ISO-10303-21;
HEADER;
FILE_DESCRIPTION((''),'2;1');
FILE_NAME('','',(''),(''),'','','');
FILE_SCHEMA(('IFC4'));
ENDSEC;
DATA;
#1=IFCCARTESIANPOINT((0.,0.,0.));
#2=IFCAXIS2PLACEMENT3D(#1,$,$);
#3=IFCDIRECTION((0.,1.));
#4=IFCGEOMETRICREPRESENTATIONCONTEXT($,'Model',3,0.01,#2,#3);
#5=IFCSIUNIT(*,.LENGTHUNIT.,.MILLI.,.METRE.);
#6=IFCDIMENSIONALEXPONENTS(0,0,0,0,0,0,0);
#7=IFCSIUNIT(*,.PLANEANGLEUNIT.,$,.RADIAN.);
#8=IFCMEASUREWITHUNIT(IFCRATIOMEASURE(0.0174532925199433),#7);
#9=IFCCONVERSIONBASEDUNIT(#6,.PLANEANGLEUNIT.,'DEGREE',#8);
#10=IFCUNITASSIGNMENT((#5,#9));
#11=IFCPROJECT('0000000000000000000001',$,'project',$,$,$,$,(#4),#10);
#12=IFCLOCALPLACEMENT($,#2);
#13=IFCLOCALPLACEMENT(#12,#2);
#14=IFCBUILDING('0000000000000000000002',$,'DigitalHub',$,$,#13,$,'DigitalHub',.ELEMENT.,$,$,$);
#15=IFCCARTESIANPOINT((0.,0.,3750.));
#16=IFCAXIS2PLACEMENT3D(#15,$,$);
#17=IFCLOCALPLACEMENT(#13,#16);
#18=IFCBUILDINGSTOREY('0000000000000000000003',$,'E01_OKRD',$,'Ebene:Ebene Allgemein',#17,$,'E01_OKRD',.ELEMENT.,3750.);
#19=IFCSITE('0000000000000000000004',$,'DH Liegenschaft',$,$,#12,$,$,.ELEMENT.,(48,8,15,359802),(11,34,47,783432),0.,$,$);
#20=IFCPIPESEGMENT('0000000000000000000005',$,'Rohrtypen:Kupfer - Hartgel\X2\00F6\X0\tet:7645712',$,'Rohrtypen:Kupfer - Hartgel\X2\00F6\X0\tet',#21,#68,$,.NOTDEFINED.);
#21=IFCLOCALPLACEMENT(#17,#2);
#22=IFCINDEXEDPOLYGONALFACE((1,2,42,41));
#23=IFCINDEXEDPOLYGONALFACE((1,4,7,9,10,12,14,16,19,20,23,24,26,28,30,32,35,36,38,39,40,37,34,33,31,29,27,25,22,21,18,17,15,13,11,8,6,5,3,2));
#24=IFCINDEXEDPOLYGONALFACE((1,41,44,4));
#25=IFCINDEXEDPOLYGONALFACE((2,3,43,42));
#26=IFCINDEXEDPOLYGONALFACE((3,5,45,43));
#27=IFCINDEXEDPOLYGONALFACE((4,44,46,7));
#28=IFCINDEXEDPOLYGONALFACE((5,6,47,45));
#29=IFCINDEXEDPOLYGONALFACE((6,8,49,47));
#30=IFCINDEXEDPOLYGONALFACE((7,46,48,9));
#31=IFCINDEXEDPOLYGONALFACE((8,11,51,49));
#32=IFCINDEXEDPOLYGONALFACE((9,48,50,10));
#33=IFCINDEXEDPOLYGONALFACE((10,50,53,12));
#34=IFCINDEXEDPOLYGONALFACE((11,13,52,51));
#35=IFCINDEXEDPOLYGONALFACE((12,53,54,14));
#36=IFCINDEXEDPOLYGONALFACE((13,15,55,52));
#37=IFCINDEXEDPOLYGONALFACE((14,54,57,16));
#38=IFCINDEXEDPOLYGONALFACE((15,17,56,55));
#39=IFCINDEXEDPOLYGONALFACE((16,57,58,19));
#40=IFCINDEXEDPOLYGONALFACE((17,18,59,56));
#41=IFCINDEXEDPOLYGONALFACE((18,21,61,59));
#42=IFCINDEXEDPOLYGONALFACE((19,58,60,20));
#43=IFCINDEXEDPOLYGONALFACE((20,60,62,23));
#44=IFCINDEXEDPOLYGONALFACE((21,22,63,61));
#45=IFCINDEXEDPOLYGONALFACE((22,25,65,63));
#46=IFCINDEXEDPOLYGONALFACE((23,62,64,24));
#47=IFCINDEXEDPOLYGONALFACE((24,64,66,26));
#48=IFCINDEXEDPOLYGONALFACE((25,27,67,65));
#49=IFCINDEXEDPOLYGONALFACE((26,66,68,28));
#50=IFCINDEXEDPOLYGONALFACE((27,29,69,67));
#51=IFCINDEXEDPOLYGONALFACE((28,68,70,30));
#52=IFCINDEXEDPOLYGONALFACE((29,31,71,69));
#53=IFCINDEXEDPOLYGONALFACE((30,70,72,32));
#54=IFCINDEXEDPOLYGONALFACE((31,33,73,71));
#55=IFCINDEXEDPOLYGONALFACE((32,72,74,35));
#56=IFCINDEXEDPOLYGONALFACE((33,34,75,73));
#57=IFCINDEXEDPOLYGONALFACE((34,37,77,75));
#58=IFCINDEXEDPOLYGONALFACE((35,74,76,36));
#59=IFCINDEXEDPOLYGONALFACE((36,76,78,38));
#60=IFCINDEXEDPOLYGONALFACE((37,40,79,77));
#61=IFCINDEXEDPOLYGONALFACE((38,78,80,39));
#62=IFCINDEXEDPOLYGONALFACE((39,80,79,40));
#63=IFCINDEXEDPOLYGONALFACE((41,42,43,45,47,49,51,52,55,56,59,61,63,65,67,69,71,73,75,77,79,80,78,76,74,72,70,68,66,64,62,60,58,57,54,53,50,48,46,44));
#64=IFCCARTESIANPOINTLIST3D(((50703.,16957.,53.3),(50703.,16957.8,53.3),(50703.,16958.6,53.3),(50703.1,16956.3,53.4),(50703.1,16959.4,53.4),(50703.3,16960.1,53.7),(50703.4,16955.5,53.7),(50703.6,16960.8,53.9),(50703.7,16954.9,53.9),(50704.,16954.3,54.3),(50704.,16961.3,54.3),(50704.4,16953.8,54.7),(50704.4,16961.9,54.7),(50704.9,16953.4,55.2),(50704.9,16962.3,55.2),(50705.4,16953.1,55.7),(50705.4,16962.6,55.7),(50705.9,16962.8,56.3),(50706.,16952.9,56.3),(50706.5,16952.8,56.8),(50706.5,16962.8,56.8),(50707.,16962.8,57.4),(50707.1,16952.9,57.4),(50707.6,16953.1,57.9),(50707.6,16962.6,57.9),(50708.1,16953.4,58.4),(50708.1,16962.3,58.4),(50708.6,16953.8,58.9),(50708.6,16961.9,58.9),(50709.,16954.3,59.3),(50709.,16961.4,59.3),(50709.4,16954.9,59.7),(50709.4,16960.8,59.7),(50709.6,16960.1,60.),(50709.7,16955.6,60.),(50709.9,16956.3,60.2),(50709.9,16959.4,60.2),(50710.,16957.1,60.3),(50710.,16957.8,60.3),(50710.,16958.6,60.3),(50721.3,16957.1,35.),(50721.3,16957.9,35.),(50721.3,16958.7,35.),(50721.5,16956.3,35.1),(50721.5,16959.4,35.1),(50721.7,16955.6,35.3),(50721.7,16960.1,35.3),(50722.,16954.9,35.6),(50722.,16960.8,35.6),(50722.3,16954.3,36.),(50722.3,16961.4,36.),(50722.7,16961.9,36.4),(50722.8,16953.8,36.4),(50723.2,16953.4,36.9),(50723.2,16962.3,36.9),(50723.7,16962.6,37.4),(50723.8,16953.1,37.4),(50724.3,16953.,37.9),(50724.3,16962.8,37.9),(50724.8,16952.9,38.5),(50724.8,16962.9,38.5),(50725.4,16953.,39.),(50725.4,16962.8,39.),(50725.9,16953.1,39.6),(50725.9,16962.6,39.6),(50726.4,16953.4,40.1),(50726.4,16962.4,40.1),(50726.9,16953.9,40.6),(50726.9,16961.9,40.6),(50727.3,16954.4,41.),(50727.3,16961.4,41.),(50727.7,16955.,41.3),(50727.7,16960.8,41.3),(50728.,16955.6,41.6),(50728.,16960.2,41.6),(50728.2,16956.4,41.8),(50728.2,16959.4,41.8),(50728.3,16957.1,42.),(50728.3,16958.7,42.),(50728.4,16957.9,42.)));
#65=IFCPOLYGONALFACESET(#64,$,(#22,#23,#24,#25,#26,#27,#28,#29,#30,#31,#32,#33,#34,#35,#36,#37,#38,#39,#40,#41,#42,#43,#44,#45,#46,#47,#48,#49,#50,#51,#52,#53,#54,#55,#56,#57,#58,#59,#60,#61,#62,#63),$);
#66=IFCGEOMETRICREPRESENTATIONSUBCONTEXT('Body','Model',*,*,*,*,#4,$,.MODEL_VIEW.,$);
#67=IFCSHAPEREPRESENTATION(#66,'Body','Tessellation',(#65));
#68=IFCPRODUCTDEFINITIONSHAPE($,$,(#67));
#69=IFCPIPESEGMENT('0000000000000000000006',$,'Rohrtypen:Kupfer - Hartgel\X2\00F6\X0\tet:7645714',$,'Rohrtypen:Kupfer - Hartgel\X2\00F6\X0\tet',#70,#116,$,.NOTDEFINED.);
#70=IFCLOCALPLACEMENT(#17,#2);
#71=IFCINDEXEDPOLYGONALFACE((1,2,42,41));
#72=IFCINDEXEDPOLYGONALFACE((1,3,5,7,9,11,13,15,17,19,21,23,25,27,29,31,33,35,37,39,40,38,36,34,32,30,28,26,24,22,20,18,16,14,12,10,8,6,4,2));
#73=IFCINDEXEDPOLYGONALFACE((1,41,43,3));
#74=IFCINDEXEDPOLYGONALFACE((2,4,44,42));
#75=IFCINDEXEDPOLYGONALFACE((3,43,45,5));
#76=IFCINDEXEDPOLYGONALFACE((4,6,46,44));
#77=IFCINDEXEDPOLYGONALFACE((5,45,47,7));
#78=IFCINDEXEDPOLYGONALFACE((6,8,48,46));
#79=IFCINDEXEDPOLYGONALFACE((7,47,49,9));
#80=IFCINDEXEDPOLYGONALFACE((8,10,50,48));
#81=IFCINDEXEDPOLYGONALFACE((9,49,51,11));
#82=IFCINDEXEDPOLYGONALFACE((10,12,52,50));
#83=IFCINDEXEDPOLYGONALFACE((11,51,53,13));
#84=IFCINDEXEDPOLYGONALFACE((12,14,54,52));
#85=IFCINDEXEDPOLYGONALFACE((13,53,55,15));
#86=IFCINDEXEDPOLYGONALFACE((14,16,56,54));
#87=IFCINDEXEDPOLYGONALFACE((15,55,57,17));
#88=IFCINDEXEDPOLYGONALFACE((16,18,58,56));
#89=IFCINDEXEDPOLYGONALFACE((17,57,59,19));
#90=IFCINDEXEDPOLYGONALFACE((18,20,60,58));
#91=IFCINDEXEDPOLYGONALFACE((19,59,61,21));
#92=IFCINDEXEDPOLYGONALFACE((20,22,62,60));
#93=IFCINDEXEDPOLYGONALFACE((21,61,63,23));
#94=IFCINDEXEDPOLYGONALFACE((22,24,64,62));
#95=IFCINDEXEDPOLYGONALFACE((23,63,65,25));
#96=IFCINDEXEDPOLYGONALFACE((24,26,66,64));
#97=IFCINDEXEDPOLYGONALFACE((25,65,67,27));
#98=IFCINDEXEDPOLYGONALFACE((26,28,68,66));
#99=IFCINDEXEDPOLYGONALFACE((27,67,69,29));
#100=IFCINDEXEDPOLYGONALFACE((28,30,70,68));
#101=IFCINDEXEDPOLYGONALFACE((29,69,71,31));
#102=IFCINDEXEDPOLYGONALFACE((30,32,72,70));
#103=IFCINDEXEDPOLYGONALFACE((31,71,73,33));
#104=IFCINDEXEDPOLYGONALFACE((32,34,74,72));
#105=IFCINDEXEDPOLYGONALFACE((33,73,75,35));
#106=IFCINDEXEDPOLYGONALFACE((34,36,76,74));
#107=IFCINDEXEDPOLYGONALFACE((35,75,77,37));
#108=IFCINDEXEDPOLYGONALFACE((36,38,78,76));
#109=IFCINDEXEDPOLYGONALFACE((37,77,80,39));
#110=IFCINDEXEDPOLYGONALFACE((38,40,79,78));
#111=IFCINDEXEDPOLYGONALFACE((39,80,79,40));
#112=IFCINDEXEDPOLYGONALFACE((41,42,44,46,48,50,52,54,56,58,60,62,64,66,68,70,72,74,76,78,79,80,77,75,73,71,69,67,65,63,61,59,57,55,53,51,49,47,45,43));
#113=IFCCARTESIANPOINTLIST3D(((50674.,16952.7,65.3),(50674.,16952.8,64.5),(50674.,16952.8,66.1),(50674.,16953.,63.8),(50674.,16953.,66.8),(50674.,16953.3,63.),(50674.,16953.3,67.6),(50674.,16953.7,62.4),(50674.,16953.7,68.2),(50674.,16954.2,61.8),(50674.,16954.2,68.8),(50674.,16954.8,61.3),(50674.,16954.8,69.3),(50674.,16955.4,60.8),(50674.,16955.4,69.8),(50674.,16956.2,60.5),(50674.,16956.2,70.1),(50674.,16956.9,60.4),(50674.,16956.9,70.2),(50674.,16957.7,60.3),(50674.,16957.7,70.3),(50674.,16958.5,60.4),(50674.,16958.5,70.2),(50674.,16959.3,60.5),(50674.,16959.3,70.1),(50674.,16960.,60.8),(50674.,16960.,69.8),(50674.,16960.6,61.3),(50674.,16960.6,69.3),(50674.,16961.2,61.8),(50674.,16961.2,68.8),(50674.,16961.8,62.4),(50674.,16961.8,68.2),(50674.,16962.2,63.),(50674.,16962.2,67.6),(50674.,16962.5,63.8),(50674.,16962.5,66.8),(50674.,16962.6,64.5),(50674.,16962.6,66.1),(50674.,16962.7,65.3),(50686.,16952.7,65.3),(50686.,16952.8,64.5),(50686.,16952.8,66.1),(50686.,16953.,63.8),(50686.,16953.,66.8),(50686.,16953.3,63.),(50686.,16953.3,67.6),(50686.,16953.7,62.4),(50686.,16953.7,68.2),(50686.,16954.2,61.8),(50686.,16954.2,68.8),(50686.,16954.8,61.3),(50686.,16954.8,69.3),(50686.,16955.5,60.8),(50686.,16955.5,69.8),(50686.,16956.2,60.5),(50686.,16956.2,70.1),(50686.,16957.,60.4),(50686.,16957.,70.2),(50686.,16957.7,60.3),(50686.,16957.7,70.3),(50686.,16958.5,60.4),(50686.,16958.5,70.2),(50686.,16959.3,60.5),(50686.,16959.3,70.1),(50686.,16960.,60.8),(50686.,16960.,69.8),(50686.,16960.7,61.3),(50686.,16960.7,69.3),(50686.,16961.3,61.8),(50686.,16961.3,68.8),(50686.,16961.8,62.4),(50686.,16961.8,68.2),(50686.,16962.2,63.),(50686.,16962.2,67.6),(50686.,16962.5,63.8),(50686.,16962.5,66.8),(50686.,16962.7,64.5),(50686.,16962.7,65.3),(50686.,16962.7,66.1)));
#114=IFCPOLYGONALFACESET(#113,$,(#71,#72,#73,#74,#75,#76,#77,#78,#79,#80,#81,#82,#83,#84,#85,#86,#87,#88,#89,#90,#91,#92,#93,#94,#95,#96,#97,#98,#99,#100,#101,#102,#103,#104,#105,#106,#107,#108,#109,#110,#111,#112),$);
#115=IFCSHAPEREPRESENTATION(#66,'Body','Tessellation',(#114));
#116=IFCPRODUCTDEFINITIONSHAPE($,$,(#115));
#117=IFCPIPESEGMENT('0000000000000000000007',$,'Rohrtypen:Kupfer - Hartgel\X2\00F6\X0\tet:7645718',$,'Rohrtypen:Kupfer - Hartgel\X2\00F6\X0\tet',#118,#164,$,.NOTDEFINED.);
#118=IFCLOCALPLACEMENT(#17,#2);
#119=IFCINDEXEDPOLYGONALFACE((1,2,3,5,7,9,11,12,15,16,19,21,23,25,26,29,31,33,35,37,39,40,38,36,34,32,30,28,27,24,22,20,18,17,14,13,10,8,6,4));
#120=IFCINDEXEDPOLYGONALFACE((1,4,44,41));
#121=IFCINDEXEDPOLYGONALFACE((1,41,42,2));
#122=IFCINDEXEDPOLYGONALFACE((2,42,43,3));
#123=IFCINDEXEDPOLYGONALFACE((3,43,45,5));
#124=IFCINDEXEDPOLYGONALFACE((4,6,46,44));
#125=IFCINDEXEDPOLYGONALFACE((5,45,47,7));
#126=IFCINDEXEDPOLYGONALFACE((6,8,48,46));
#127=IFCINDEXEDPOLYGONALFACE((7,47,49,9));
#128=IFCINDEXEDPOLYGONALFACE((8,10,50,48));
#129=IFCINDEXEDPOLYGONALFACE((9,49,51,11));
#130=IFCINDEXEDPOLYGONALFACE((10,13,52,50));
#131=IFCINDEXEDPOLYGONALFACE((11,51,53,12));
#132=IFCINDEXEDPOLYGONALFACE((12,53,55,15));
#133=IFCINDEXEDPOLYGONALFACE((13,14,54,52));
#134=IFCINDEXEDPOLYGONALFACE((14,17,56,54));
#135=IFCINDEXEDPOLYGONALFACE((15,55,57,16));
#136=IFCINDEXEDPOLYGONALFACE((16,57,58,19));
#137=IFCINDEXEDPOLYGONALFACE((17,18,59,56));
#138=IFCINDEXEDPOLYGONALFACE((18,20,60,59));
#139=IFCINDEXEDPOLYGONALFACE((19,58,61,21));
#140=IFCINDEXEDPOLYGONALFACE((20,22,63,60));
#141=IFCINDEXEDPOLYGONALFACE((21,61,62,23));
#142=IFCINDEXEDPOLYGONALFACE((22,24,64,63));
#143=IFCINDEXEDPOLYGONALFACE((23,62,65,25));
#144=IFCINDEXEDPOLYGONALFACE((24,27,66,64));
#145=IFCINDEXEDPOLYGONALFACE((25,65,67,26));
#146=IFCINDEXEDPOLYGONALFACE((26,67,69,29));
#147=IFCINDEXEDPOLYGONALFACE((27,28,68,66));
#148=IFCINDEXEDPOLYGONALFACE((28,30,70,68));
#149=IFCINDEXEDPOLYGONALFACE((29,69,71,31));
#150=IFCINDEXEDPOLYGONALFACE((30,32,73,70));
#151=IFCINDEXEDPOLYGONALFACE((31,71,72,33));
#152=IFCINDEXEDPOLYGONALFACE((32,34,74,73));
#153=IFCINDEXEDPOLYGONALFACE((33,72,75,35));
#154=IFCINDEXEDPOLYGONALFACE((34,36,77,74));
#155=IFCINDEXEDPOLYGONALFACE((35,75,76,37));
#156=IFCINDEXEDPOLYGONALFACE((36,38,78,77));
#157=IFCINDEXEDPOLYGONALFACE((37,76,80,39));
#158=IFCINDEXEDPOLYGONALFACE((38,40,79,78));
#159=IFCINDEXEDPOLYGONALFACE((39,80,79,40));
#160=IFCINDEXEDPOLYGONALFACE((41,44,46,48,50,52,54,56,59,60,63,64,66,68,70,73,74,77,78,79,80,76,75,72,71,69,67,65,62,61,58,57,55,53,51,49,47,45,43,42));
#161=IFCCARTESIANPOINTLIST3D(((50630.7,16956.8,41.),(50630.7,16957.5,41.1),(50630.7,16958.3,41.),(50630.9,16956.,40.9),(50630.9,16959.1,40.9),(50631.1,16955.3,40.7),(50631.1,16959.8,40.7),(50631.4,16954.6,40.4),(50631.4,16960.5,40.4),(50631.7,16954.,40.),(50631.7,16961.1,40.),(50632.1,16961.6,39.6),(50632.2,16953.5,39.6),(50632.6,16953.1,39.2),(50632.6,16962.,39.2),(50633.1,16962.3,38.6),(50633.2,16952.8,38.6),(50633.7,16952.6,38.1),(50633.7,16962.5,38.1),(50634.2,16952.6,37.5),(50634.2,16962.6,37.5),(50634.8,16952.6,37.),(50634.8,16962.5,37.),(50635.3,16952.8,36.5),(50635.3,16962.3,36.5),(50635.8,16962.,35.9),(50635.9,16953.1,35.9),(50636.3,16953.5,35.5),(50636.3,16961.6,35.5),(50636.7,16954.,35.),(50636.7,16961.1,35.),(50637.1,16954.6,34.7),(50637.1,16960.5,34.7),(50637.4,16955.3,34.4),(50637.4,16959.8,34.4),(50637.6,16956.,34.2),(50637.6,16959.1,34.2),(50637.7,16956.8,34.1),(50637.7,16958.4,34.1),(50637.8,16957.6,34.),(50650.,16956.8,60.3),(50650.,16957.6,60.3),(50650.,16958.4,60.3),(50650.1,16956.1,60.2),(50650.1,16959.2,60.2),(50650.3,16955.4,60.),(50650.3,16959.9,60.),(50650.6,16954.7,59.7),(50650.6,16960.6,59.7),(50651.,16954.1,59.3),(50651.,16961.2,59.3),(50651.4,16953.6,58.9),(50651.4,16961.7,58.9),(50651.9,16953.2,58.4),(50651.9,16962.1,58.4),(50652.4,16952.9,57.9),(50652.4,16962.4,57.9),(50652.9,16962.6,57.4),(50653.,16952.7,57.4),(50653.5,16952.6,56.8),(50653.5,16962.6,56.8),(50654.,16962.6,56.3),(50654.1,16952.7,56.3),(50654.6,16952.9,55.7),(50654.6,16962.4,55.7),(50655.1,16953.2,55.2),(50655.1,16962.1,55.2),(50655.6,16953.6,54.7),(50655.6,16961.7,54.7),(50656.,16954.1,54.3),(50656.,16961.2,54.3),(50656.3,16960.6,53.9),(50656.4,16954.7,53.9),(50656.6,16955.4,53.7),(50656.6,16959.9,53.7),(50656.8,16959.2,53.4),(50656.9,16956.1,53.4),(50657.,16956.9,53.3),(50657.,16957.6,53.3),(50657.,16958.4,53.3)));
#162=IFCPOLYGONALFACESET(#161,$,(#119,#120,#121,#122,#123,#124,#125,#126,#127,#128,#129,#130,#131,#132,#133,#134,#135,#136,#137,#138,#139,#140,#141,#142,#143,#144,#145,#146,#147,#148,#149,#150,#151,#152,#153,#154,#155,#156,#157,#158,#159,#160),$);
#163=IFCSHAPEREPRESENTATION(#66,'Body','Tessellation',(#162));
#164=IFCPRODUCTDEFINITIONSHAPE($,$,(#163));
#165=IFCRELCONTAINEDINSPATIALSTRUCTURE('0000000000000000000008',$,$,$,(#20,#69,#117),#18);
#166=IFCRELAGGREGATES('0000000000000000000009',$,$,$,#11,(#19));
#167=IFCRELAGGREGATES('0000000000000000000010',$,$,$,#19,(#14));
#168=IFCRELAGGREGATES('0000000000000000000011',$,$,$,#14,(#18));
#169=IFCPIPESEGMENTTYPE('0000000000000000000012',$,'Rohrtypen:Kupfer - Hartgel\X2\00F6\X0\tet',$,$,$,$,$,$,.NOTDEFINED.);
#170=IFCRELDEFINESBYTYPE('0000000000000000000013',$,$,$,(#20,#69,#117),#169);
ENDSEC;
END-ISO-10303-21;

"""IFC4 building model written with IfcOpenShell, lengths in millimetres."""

from ifc_helpers import new_model, entity, si_unit, converted_unit, direction, frame, origin, place, context, subcontext, project, spatial, indexed_curve, outline, extrude, type_object, element, save


model = new_model("IFC4")

# Units and contexts
model_context = context("Model", 3, precision=0.01, world=origin(), true_north=direction((0.0, 1.0)))
body_context = subcontext(model_context, "Body", "Model", "MODEL_VIEW")
ifc_project = project(units=[si_unit("LENGTHUNIT", "METRE", prefix="MILLI"), converted_unit("PLANEANGLEUNIT", "DEGREE", entity("IfcRatioMeasure", 0.0174532925199433), si_unit("PLANEANGLEUNIT", "RADIAN"), dimensions=[0, 0, 0, 0, 0, 0, 0])], contexts=[model_context])

# Site, building, storey
site_placement = place(None, origin())
site = spatial("IfcSite", under=ifc_project, at=site_placement, Name="DH Liegenschaft", CompositionType="ELEMENT", RefLatitude=(48, 8, 15, 359802), RefLongitude=(11, 34, 47, 783432), RefElevation=0.0)
building_placement = place(site_placement, origin())
building = spatial("IfcBuilding", under=site, at=building_placement, Name="DigitalHub", LongName="DigitalHub", CompositionType="ELEMENT")
storey_placement = place(building_placement, frame((0.0, 0.0, 3750.0)))
storey = spatial("IfcBuildingStorey", under=building, at=storey_placement, Name="E01_OKRD", ObjectType="Ebene:Ebene Allgemein", LongName="E01_OKRD", CompositionType="ELEMENT", Elevation=3750.0)

# Pipe segments
pipe_segment_type = type_object("IfcPipeSegmentType", Name="Rohrtypen:Kupfer - Hartgelötet", PredefinedType="NOTDEFINED")
pipe_segment_1_placement = place(storey_placement, frame((50701.4, 16951.2, 33.4)))
element("IfcPipeSegment", 1, at=pipe_segment_1_placement, inside=storey, type_object=pipe_segment_type, Name="Rohrtypen:Kupfer - Hartgelötet:7645712", ObjectType="Rohrtypen:Kupfer - Hartgelötet", PredefinedType="NOTDEFINED", context=body_context, shape_type="SweptSolid", body=[
    extrude(outline(indexed_curve([(5.0, 0.0), (4.9, 0.8), (4.8, 1.5), (4.5, 2.3), (4.0, 2.9), (3.5, 3.5), (2.9, 4.0), (2.3, 4.5), (1.5, 4.8), (0.8, 4.9), (0.0, 5.0), (-0.8, 4.9), (-1.5, 4.8), (-2.3, 4.5), (-2.9, 4.0), (-3.5, 3.5), (-4.0, 2.9), (-4.5, 2.3), (-4.8, 1.5), (-4.9, 0.8), (-5.0, 0.0), (-4.9, -0.8), (-4.8, -1.5), (-4.5, -2.3), (-4.0, -2.9), (-3.5, -3.5), (-2.9, -4.0), (-2.3, -4.5), (-1.5, -4.8), (-0.8, -4.9), (0.0, -5.0), (0.8, -4.9), (1.5, -4.8), (2.3, -4.5), (2.9, -4.0), (3.5, -3.5), (4.0, -2.9), (4.5, -2.3), (4.8, -1.5), (4.9, -0.8), (5.0, 0.0)], self_intersect=False)), frame((5.1, 6.6, 23.5), z_axis=(0.707102, 0.002602, -0.707107), x_axis=(-0.003679, 0.999993, 0.0)), (0.0, 0.0, 1.0), 25.9),
])
pipe_segment_2_placement = place(storey_placement, frame((50674.0, 16951.1, 58.7)))
element("IfcPipeSegment", 2, at=pipe_segment_2_placement, inside=storey, type_object=pipe_segment_type, Name="Rohrtypen:Kupfer - Hartgelötet:7645714", ObjectType="Rohrtypen:Kupfer - Hartgelötet", PredefinedType="NOTDEFINED", context=body_context, shape_type="SweptSolid", body=[
    extrude(outline(indexed_curve([(5.0, 0.0), (4.9, 0.8), (4.8, 1.5), (4.5, 2.3), (4.0, 2.9), (3.5, 3.5), (2.9, 4.0), (2.3, 4.5), (1.5, 4.8), (0.8, 4.9), (0.0, 5.0), (-0.8, 4.9), (-1.5, 4.8), (-2.3, 4.5), (-2.9, 4.0), (-3.5, 3.5), (-4.0, 2.9), (-4.5, 2.3), (-4.8, 1.5), (-4.9, 0.8), (-5.0, 0.0), (-4.9, -0.8), (-4.8, -1.5), (-4.5, -2.3), (-4.0, -2.9), (-3.5, -3.5), (-2.9, -4.0), (-2.3, -4.5), (-1.5, -4.8), (-0.8, -4.9), (0.0, -5.0), (0.8, -4.9), (1.5, -4.8), (2.3, -4.5), (2.9, -4.0), (3.5, -3.5), (4.0, -2.9), (4.5, -2.3), (4.8, -1.5), (4.9, -0.8), (5.0, 0.0)], self_intersect=False)), frame((0.0, 6.6, 6.6), z_axis=(0.999995, 0.003297, 0.0), x_axis=(-0.003297, 0.999995, 0.0)), (0.0, 0.0, 1.0), 12.0),
])
pipe_segment_3_placement = place(storey_placement, frame((50629.1, 16951.0, 32.4)))
element("IfcPipeSegment", 3, at=pipe_segment_3_placement, inside=storey, type_object=pipe_segment_type, Name="Rohrtypen:Kupfer - Hartgelötet:7645718", ObjectType="Rohrtypen:Kupfer - Hartgelötet", PredefinedType="NOTDEFINED", context=body_context, shape_type="SweptSolid", body=[
    extrude(outline(indexed_curve([(5.0, 0.0), (4.9, 0.8), (4.8, 1.5), (4.5, 2.3), (4.0, 2.9), (3.5, 3.5), (2.9, 4.0), (2.3, 4.5), (1.5, 4.8), (0.8, 4.9), (0.0, 5.0), (-0.8, 4.9), (-1.5, 4.8), (-2.3, 4.5), (-2.9, 4.0), (-3.5, 3.5), (-4.0, 2.9), (-4.5, 2.3), (-4.8, 1.5), (-4.9, 0.8), (-5.0, 0.0), (-4.9, -0.8), (-4.8, -1.5), (-4.5, -2.3), (-4.0, -2.9), (-3.5, -3.5), (-2.9, -4.0), (-2.3, -4.5), (-1.5, -4.8), (-0.8, -4.9), (0.0, -5.0), (0.8, -4.9), (1.5, -4.8), (2.3, -4.5), (2.9, -4.0), (3.5, -3.5), (4.0, -2.9), (4.5, -2.3), (4.8, -1.5), (4.9, -0.8), (5.0, 0.0)], self_intersect=False)), frame((5.1, 6.6, 5.1), z_axis=(0.707102, 0.002602, 0.707107), x_axis=(-0.003679, 0.999993, 0.0)), (0.0, 0.0, 1.0), 27.2),
])

save(model, "model.ifc")
